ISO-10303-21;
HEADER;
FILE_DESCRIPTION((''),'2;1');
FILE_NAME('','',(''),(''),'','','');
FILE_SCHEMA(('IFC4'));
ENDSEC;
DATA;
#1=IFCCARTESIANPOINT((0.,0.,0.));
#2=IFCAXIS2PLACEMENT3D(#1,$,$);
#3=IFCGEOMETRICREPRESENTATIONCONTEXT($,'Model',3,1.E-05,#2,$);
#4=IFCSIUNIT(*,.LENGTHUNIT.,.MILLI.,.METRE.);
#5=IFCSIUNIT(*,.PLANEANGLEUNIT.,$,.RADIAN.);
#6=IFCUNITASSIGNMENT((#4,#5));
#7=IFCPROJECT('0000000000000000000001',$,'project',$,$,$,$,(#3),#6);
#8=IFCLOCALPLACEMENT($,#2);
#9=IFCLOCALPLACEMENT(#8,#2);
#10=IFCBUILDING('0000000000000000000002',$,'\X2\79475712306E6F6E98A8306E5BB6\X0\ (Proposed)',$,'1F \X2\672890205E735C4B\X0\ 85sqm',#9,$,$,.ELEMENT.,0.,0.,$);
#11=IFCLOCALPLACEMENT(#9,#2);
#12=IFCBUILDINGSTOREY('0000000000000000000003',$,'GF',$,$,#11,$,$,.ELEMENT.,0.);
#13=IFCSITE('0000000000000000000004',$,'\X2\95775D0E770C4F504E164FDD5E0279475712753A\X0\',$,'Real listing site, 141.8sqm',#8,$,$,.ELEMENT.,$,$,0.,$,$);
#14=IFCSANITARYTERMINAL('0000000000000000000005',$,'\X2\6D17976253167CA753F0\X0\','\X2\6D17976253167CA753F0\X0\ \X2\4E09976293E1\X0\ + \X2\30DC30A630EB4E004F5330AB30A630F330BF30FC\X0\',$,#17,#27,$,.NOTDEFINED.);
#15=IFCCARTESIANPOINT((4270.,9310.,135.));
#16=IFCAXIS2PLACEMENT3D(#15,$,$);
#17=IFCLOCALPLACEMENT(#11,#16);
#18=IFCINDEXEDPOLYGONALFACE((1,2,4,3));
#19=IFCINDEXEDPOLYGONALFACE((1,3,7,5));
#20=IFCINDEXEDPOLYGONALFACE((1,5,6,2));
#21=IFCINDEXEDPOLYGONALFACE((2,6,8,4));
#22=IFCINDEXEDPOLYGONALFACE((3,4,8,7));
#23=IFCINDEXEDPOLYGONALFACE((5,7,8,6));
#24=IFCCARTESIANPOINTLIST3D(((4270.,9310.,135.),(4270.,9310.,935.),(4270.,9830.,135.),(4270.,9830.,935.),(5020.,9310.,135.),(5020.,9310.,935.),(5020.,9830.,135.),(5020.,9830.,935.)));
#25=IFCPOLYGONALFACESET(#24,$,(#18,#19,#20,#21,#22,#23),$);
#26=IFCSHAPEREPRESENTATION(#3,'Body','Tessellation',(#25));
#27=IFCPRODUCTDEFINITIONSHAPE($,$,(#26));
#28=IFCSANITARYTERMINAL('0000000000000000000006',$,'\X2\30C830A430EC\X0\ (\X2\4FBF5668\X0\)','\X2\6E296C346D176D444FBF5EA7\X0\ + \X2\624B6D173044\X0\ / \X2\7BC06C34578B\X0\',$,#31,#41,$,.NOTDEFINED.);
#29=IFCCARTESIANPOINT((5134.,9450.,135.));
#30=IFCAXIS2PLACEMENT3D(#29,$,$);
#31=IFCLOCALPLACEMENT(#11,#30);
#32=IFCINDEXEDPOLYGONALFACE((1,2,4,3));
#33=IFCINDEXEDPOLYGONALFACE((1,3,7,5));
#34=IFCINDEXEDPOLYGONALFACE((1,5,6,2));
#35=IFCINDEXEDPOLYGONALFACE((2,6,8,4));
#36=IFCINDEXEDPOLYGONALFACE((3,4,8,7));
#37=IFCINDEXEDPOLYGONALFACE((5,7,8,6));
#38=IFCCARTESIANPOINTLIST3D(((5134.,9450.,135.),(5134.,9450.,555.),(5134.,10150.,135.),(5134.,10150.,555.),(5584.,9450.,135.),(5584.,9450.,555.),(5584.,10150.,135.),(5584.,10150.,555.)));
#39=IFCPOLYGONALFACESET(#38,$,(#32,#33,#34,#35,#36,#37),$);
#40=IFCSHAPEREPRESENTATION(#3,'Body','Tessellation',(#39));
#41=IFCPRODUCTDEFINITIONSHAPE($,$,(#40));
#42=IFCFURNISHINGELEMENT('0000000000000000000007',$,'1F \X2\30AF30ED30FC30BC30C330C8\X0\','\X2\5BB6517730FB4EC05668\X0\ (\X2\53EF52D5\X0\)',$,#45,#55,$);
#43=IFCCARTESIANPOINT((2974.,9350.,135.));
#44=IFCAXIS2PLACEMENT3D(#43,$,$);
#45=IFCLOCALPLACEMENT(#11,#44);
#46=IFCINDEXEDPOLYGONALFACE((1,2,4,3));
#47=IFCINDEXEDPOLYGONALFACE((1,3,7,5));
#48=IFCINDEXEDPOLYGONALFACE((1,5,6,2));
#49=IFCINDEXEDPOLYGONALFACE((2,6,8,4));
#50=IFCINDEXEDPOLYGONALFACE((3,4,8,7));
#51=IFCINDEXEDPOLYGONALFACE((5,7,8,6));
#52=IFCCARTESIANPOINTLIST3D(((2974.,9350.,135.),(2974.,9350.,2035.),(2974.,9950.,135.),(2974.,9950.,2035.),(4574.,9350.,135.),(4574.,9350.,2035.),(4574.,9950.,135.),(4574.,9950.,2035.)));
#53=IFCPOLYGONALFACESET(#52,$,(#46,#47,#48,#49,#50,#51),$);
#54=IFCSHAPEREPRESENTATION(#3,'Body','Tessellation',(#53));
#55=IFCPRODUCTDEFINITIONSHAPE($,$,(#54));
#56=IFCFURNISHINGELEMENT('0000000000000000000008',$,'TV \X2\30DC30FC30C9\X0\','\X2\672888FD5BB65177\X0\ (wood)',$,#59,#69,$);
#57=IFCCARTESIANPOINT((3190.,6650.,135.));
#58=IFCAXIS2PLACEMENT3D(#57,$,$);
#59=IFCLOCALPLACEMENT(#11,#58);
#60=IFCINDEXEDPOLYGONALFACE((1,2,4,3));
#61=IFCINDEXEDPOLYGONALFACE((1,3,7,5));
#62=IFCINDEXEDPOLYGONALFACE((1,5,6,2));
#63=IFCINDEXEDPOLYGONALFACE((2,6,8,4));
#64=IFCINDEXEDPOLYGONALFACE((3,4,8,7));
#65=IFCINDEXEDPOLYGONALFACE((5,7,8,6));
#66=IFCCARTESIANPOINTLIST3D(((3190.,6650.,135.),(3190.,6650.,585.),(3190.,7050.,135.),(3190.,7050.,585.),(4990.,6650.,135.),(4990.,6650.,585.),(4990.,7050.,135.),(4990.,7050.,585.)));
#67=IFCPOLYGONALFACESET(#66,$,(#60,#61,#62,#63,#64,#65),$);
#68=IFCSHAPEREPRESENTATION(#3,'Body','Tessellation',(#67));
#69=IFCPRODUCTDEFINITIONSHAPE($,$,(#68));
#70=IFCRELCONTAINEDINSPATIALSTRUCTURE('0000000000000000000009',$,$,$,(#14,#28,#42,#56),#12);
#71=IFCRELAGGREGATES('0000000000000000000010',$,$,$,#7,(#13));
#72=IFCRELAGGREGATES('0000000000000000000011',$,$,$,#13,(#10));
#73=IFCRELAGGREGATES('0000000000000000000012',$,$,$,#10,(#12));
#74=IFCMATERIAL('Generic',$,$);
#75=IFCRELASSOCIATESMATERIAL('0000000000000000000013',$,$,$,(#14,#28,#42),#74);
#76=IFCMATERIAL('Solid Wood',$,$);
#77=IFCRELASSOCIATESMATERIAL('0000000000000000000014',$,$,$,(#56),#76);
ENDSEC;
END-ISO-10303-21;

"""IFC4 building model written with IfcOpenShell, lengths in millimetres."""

from ifc_helpers import new_model, si_unit, frame, frame_2d, origin, place, context, project, spatial, rectangle, extrude, material, element, save


model = new_model("IFC4")

# Units and contexts
model_context = context("Model", 3, precision=1e-05, world=origin())
ifc_project = project(units=[si_unit("LENGTHUNIT", "METRE", prefix="MILLI"), si_unit("PLANEANGLEUNIT", "RADIAN")], contexts=[model_context])

# Site, building, storey
site_placement = place(None, origin())
site = spatial("IfcSite", under=ifc_project, at=site_placement, Name="長崎県佐世保市祇園町", ObjectType="Real listing site, 141.8sqm", CompositionType="ELEMENT", RefElevation=0.0)
building_placement = place(site_placement, origin())
building = spatial("IfcBuilding", under=site, at=building_placement, Name="祇園の潮風の家 (Proposed)", ObjectType="1F 木造平屋 85sqm", CompositionType="ELEMENT", ElevationOfRefHeight=0.0, ElevationOfTerrain=0.0)
storey_placement = place(building_placement, origin())
storey = spatial("IfcBuildingStorey", under=building, at=storey_placement, Name="GF", CompositionType="ELEMENT", Elevation=0.0)

# Shared definitions
ifc_material_1 = material(Name="Solid Wood")

# Shared definitions
ifc_material_2 = material(Name="Generic")

# Sanitary terminals
sanitary_terminal_1_placement = place(storey_placement, frame((4270.0, 9310.0, 135.0)))
element("IfcSanitaryTerminal", 1, at=sanitary_terminal_1_placement, inside=storey, material=ifc_material_2, Name="洗面化粧台", Description="洗面化粧台 三面鏡 + ボウル一体カウンター", PredefinedType="NOTDEFINED", context=model_context, shape_type="SweptSolid", body=[
    extrude(rectangle(XDim=750.0, YDim=520.0, at=frame_2d((375.0, 260.0))), frame((4270.0, 9310.0, 135.0)), (0.0, 0.0, 1.0), 800.0),
])
sanitary_terminal_2_placement = place(storey_placement, frame((5134.0, 9450.0, 135.0)))
element("IfcSanitaryTerminal", 2, at=sanitary_terminal_2_placement, inside=storey, material=ifc_material_2, Name="トイレ (便器)", Description="温水洗浄便座 + 手洗い / 節水型", PredefinedType="NOTDEFINED", context=model_context, shape_type="SweptSolid", body=[
    extrude(rectangle(XDim=450.0, YDim=700.0, at=frame_2d((225.0, 350.0))), frame((5134.0, 9450.0, 135.0)), (0.0, 0.0, 1.0), 420.0),
])

# Furnishing elements
furnishing_1_placement = place(storey_placement, frame((2974.0, 9350.0, 135.0)))
element("IfcFurnishingElement", 3, at=furnishing_1_placement, inside=storey, material=ifc_material_2, Name="1F クローゼット", Description="家具・什器 (可動)", context=model_context, shape_type="SweptSolid", body=[
    extrude(rectangle(XDim=1600.0, YDim=600.0, at=frame_2d((800.0, 300.0))), frame((2974.0, 9350.0, 135.0)), (0.0, 0.0, 1.0), 1900.0),
])
furnishing_2_placement = place(storey_placement, frame((3190.0, 6650.0, 135.0)))
element("IfcFurnishingElement", 4, at=furnishing_2_placement, inside=storey, material=ifc_material_1, Name="TV ボード", Description="木製家具 (wood)", context=model_context, shape_type="SweptSolid", body=[
    extrude(rectangle(XDim=1800.0, YDim=400.0, at=frame_2d((900.0, 200.0))), frame((3190.0, 6650.0, 135.0)), (0.0, 0.0, 1.0), 450.0),
])

save(model, "model.ifc")
